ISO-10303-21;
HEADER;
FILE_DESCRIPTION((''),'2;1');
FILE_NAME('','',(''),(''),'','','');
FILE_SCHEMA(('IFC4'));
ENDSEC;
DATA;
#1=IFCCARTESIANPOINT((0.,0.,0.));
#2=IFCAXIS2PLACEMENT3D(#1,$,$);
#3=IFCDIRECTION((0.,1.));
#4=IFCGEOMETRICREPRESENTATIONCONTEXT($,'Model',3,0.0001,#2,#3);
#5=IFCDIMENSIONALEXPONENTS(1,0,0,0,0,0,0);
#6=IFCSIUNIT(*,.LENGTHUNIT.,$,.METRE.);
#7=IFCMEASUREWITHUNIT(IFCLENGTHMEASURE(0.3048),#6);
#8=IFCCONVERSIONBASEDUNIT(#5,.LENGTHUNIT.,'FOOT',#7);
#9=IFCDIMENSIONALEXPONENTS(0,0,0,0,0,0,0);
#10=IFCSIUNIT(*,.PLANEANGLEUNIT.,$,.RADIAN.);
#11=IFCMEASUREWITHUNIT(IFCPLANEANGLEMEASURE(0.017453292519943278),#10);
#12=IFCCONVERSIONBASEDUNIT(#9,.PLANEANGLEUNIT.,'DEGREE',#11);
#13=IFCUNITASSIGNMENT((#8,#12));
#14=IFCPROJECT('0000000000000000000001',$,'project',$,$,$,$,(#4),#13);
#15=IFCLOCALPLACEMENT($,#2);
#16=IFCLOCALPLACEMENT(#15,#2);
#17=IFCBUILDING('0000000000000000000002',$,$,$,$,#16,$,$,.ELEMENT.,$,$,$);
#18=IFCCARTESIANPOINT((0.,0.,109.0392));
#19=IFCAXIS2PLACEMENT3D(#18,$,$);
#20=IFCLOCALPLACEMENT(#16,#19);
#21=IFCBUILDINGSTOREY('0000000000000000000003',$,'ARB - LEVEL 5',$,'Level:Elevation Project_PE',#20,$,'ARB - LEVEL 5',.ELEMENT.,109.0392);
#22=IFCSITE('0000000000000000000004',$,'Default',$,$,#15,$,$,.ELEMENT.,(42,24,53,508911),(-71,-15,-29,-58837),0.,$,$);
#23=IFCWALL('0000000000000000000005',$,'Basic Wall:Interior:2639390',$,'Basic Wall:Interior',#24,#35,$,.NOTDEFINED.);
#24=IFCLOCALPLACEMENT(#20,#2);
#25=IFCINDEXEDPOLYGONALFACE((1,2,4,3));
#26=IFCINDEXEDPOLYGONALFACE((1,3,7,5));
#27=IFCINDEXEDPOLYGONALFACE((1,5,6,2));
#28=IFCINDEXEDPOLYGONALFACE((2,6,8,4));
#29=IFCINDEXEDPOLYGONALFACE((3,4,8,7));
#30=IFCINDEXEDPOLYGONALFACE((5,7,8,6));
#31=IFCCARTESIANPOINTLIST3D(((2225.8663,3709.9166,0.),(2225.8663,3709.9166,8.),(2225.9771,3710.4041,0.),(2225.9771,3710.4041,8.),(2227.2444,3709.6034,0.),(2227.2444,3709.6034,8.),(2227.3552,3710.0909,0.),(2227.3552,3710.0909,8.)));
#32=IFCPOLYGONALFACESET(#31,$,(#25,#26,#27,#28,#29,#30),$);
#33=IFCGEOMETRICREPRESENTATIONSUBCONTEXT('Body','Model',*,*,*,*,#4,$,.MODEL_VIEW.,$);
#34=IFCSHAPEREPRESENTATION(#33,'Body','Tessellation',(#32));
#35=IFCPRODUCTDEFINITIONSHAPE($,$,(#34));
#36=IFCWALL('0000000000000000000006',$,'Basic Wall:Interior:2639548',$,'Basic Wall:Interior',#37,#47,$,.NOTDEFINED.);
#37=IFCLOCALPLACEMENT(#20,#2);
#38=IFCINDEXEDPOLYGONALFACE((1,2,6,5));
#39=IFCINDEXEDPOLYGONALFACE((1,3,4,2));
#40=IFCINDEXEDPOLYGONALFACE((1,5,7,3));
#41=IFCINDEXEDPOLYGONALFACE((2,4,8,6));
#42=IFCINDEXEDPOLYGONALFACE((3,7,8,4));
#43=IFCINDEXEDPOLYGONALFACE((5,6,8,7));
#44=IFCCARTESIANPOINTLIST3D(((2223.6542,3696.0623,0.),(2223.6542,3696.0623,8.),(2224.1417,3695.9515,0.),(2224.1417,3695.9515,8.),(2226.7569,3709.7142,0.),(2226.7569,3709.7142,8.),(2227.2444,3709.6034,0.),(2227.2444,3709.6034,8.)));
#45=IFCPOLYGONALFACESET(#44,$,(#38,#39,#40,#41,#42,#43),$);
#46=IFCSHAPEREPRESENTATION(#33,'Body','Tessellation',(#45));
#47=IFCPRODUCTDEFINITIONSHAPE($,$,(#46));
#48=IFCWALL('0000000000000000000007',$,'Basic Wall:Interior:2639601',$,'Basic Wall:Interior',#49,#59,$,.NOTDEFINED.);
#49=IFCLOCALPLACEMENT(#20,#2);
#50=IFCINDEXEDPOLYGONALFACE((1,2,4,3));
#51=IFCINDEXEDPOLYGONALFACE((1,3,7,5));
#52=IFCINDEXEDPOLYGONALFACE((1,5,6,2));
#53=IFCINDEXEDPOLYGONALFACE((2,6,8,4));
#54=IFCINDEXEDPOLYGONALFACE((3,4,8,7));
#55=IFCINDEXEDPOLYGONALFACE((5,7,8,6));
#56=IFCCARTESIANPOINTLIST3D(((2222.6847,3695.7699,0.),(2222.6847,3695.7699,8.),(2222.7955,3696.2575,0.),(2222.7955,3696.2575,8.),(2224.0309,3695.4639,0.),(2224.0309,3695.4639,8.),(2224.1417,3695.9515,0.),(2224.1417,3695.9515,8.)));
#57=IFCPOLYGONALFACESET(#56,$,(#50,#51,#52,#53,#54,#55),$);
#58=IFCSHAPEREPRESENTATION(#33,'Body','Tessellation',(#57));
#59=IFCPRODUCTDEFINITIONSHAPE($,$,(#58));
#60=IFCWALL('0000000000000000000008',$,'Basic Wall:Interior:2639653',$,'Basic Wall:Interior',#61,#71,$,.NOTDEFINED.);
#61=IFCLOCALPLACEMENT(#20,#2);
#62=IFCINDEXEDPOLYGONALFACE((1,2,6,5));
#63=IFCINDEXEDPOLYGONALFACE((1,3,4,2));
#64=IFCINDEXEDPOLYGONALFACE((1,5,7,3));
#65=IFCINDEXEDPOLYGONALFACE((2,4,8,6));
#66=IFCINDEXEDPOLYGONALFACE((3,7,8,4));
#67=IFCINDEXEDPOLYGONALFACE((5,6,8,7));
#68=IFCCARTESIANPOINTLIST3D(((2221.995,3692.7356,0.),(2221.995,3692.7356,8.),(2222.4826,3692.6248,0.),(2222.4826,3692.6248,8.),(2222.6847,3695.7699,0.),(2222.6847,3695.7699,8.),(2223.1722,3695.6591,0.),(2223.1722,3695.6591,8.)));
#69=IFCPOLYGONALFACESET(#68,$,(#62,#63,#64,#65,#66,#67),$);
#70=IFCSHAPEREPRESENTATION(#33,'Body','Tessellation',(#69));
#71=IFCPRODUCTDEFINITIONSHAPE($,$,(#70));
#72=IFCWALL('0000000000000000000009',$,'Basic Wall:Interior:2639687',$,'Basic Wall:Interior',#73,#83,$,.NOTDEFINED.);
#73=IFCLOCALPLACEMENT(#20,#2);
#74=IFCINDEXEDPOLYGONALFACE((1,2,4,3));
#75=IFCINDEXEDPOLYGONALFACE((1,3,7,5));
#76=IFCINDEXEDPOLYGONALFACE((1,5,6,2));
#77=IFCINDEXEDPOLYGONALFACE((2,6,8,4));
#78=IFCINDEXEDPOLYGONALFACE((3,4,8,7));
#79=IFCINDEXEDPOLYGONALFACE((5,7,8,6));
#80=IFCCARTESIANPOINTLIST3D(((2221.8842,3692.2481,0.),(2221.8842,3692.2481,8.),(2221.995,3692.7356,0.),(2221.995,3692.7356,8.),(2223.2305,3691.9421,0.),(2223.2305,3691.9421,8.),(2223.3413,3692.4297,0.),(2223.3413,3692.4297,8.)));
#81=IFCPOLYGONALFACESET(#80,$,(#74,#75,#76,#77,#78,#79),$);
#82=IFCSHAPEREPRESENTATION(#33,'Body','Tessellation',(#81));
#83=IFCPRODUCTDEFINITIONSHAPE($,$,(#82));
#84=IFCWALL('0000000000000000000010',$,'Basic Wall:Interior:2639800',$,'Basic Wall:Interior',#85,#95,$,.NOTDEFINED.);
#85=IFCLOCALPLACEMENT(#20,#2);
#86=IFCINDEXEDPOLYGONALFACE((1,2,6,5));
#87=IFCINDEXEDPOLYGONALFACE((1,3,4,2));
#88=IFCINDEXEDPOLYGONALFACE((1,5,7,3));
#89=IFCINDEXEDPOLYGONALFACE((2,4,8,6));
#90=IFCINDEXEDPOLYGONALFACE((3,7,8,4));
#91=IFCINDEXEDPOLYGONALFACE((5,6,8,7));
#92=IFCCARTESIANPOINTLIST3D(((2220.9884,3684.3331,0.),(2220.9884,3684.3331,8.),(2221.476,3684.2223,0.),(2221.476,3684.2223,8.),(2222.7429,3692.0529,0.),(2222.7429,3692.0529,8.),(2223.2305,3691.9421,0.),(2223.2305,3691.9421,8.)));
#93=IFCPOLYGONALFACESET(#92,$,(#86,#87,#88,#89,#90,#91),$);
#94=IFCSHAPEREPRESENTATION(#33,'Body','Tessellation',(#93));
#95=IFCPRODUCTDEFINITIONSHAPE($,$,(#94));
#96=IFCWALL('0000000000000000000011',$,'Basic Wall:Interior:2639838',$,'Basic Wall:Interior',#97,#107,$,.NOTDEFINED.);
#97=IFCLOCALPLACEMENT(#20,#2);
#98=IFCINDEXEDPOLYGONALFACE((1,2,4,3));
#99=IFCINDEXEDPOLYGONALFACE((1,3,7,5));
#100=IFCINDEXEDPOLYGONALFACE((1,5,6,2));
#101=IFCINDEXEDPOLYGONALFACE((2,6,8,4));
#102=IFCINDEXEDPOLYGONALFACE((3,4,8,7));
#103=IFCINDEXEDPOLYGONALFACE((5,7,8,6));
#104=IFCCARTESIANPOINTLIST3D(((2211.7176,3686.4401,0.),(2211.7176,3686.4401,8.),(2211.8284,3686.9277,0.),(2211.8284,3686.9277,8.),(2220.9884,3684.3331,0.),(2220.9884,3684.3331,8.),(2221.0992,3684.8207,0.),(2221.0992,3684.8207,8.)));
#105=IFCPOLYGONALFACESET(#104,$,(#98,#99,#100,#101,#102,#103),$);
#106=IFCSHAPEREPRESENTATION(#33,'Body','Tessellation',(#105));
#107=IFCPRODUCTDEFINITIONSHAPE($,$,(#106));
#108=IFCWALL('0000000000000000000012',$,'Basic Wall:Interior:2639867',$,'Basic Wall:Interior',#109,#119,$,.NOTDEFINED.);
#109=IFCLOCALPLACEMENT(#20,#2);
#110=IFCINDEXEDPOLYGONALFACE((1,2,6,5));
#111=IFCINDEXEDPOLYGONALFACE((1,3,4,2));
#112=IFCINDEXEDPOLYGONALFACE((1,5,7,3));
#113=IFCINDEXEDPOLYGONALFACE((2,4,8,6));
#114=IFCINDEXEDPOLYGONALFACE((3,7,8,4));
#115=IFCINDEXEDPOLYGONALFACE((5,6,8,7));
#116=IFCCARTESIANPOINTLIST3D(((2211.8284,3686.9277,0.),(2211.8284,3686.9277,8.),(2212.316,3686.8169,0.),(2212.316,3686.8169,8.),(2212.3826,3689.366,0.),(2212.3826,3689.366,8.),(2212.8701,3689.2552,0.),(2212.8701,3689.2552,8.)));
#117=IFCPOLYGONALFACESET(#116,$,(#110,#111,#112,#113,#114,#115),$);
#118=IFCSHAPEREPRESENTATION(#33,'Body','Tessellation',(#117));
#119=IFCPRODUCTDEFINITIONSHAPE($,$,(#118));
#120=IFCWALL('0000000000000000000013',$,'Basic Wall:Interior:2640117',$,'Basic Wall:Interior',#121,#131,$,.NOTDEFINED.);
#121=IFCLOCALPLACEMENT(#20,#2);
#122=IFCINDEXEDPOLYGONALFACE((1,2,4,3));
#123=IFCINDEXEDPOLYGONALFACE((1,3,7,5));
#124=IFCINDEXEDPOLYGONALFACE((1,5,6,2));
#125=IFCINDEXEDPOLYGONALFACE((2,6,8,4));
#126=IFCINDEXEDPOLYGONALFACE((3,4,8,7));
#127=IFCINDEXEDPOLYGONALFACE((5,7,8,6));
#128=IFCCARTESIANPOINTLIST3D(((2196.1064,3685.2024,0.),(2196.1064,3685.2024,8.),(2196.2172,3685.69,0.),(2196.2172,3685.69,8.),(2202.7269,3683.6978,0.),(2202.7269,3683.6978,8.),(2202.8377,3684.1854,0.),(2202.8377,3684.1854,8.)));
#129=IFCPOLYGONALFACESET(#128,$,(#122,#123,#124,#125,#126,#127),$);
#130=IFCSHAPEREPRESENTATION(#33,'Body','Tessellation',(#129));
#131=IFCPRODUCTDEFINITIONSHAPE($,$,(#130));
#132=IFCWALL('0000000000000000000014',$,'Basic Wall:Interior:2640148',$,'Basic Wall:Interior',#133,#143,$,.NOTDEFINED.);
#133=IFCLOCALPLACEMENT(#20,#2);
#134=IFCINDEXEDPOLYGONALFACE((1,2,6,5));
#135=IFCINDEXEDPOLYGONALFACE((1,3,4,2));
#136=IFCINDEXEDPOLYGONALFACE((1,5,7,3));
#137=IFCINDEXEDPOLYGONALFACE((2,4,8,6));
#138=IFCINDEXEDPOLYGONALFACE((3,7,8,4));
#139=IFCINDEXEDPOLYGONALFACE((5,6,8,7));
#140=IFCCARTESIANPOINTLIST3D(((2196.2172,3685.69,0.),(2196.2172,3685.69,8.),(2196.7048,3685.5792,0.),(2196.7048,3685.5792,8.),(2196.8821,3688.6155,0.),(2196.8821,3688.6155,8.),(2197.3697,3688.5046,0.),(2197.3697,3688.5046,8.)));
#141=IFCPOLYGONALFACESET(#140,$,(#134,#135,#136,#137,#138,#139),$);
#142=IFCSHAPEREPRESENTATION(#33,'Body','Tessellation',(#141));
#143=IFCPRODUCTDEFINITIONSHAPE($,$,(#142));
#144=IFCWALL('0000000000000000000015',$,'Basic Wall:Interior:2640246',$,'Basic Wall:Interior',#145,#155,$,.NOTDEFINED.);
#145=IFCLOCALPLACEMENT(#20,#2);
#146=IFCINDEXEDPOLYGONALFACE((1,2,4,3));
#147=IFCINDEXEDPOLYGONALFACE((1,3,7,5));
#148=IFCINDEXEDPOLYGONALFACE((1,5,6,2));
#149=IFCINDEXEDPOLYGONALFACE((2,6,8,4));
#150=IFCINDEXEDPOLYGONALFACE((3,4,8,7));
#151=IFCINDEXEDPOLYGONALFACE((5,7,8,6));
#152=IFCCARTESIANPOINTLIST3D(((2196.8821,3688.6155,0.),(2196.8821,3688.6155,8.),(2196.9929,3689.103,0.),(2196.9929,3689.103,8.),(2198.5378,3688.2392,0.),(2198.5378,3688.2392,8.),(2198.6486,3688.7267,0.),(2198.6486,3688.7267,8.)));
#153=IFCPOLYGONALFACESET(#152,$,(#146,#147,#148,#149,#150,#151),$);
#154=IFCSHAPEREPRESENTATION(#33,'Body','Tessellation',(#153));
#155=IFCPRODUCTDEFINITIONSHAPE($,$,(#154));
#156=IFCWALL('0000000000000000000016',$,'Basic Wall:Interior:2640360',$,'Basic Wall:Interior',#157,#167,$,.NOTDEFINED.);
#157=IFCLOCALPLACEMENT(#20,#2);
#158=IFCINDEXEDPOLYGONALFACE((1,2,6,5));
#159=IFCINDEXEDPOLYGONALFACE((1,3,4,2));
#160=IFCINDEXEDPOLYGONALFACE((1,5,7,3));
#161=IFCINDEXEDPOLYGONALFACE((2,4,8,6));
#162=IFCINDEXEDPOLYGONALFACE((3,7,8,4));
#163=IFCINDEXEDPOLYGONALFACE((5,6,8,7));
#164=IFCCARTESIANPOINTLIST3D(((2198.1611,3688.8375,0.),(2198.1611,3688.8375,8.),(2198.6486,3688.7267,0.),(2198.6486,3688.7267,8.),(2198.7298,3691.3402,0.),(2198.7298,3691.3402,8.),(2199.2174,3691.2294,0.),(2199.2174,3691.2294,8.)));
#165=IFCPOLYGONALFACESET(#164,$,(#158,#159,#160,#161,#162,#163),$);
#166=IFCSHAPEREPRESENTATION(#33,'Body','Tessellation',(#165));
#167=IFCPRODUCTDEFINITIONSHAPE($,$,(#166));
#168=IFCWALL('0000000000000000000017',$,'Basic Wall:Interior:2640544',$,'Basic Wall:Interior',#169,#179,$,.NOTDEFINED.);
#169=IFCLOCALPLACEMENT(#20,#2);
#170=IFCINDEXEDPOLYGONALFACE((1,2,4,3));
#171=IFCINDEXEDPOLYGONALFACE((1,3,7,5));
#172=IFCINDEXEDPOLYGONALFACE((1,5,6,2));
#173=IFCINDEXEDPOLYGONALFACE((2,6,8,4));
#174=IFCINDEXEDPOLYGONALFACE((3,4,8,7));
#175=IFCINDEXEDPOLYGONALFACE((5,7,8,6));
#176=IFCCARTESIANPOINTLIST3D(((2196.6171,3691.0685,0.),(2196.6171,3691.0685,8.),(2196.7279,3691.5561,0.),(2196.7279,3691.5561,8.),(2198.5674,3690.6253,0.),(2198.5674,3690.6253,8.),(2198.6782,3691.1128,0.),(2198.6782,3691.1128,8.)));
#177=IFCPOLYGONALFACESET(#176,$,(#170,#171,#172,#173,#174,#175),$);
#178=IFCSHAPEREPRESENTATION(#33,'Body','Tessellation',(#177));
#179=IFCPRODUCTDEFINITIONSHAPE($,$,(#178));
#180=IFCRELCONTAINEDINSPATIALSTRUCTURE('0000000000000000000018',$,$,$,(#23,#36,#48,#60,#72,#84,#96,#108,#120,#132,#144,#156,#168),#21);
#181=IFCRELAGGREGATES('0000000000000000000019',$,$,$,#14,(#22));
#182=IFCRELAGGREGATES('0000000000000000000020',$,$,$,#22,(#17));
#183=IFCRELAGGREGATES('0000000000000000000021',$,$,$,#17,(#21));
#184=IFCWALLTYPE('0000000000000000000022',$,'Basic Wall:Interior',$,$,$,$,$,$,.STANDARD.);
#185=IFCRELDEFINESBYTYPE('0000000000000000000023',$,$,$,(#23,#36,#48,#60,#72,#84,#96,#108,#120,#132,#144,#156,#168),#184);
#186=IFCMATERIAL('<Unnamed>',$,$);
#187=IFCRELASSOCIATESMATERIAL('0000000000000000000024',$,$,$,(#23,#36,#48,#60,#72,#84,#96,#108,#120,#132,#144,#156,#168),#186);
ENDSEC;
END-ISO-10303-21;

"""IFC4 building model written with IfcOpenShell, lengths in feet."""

from ifc_helpers import new_model, entity, si_unit, converted_unit, direction, frame, origin, place, context, subcontext, project, spatial, indexed_curve, outline, extrude, material, type_object, element, save


model = new_model("IFC4")

# Units and contexts
model_context = context("Model", 3, precision=0.0001, world=origin(), true_north=direction((0.0, 1.0)))
body_context = subcontext(model_context, "Body", "Model", "MODEL_VIEW")
ifc_project = project(units=[converted_unit("LENGTHUNIT", "FOOT", entity("IfcLengthMeasure", 0.3048), si_unit("LENGTHUNIT", "METRE"), dimensions=[1, 0, 0, 0, 0, 0, 0]), converted_unit("PLANEANGLEUNIT", "DEGREE", entity("IfcPlaneAngleMeasure", 0.017453292519943278), si_unit("PLANEANGLEUNIT", "RADIAN"), dimensions=[0, 0, 0, 0, 0, 0, 0])], contexts=[model_context])

# Site, building, storey
site_placement = place(None, origin())
site = spatial("IfcSite", under=ifc_project, at=site_placement, Name="Default", CompositionType="ELEMENT", RefLatitude=(42, 24, 53, 508911), RefLongitude=(-71, -15, -29, -58837), RefElevation=0.0)
building_placement = place(site_placement, origin())
building = spatial("IfcBuilding", under=site, at=building_placement, CompositionType="ELEMENT")
storey_placement = place(building_placement, frame((0.0, 0.0, 109.0392)))
storey = spatial("IfcBuildingStorey", under=building, at=storey_placement, Name="ARB - LEVEL 5", ObjectType="Level:Elevation Project_PE", LongName="ARB - LEVEL 5", CompositionType="ELEMENT", Elevation=109.0392)

# Walls
ifc_material_1 = material(Name="<Unnamed>")
wall_type = type_object("IfcWallType", Name="Basic Wall:Interior", PredefinedType="STANDARD")
wall_1_placement = place(storey_placement, frame((2225.9217, 3710.1604, 0.0), z_axis=(0.0, 0.0, 1.0), x_axis=(0.975133, -0.221622, 0.0)))
element("IfcWall", 1, at=wall_1_placement, inside=storey, type_object=wall_type, material=ifc_material_1, Name="Basic Wall:Interior:2639390", ObjectType="Basic Wall:Interior", PredefinedType="NOTDEFINED", context=body_context, shape_type="SweptSolid", body=[
    extrude(outline(indexed_curve([(1.4132, 0.25), (0.0, 0.25), (0.0, -0.25), (1.4132, -0.25), (1.4132, 0.25)], self_intersect=False)), origin(), (0.0, 0.0, 1.0), 8.0),
])
wall_2_placement = place(storey_placement, frame((2227.0006, 3709.6588, 0.0), z_axis=(0.0, 0.0, 1.0), x_axis=(-0.221622, -0.975133, 0.0)))
element("IfcWall", 2, at=wall_2_placement, inside=storey, type_object=wall_type, material=ifc_material_1, Name="Basic Wall:Interior:2639548", ObjectType="Basic Wall:Interior", PredefinedType="NOTDEFINED", context=body_context, shape_type="SweptSolid", body=[
    extrude(outline(indexed_curve([(14.0, 0.25), (0.0, 0.25), (0.0, -0.25), (14.0, -0.25), (14.0, 0.25)], self_intersect=False)), origin(), (0.0, 0.0, 1.0), 8.0),
])
wall_3_placement = place(storey_placement, frame((2224.0863, 3695.7077, 0.0), z_axis=(0.0, 0.0, 1.0), x_axis=(-0.975133, 0.221622, 0.0)))
element("IfcWall", 3, at=wall_3_placement, inside=storey, type_object=wall_type, material=ifc_material_1, Name="Basic Wall:Interior:2639601", ObjectType="Basic Wall:Interior", PredefinedType="NOTDEFINED", context=body_context, shape_type="SweptSolid", body=[
    extrude(outline(indexed_curve([(1.3806, 0.25), (0.0, 0.25), (0.0, -0.25), (1.3806, -0.25), (1.3806, 0.25)], self_intersect=False)), origin(), (0.0, 0.0, 1.0), 8.0),
])
wall_4_placement = place(storey_placement, frame((2222.9284, 3695.7145, 0.0), z_axis=(0.0, 0.0, 1.0), x_axis=(-0.221622, -0.975133, 0.0)))
element("IfcWall", 4, at=wall_4_placement, inside=storey, type_object=wall_type, material=ifc_material_1, Name="Basic Wall:Interior:2639653", ObjectType="Basic Wall:Interior", PredefinedType="NOTDEFINED", context=body_context, shape_type="SweptSolid", body=[
    extrude(outline(indexed_curve([(3.1116, 0.25), (0.0, 0.25), (0.0, -0.25), (3.1116, -0.25), (3.1116, 0.25)], self_intersect=False)), origin(), (0.0, 0.0, 1.0), 8.0),
])
wall_5_placement = place(storey_placement, frame((2221.9396, 3692.4919, 0.0), z_axis=(0.0, 0.0, 1.0), x_axis=(0.975133, -0.221622, 0.0)))
element("IfcWall", 5, at=wall_5_placement, inside=storey, type_object=wall_type, material=ifc_material_1, Name="Basic Wall:Interior:2639687", ObjectType="Basic Wall:Interior", PredefinedType="NOTDEFINED", context=body_context, shape_type="SweptSolid", body=[
    extrude(outline(indexed_curve([(1.3806, 0.25), (0.0, 0.25), (0.0, -0.25), (1.3806, -0.25), (1.3806, 0.25)], self_intersect=False)), origin(), (0.0, 0.0, 1.0), 8.0),
])
wall_6_placement = place(storey_placement, frame((2222.9867, 3691.9975, 0.0), z_axis=(0.0, 0.0, 1.0), x_axis=(-0.221622, -0.975133, 0.0)))
element("IfcWall", 6, at=wall_6_placement, inside=storey, type_object=wall_type, material=ifc_material_1, Name="Basic Wall:Interior:2639800", ObjectType="Basic Wall:Interior", PredefinedType="NOTDEFINED", context=body_context, shape_type="SweptSolid", body=[
    extrude(outline(indexed_curve([(7.9167, 0.25), (0.0, 0.25), (0.0, -0.25), (7.9167, -0.25), (7.9167, 0.25)], self_intersect=False)), origin(), (0.0, 0.0, 1.0), 8.0),
])
wall_7_placement = place(storey_placement, frame((2221.0438, 3684.5769, 0.0), z_axis=(0.0, 0.0, 1.0), x_axis=(-0.975133, 0.221622, 0.0)))
element("IfcWall", 7, at=wall_7_placement, inside=storey, type_object=wall_type, material=ifc_material_1, Name="Basic Wall:Interior:2639838", ObjectType="Basic Wall:Interior", PredefinedType="NOTDEFINED", context=body_context, shape_type="SweptSolid", body=[
    extrude(outline(indexed_curve([(9.5072, 0.25), (0.0, 0.25), (0.0, -0.25), (9.5072, -0.25), (9.5072, 0.25)], self_intersect=False)), origin(), (0.0, 0.0, 1.0), 8.0),
])
wall_8_placement = place(storey_placement, frame((2212.0722, 3686.8723, 0.0), z_axis=(0.0, 0.0, 1.0), x_axis=(0.221622, 0.975133, 0.0)))
element("IfcWall", 8, at=wall_8_placement, inside=storey, type_object=wall_type, material=ifc_material_1, Name="Basic Wall:Interior:2639867", ObjectType="Basic Wall:Interior", PredefinedType="NOTDEFINED", context=body_context, shape_type="SweptSolid", body=[
    extrude(outline(indexed_curve([(2.5005, 0.25), (0.0, 0.25), (0.0, -0.25), (2.5005, -0.25), (2.5005, 0.25)], self_intersect=False)), origin(), (0.0, 0.0, 1.0), 8.0),
])
wall_9_placement = place(storey_placement, frame((2202.7823, 3683.9416, 0.0), z_axis=(0.0, 0.0, 1.0), x_axis=(-0.975133, 0.221622, 0.0)))
element("IfcWall", 9, at=wall_9_placement, inside=storey, type_object=wall_type, material=ifc_material_1, Name="Basic Wall:Interior:2640117", ObjectType="Basic Wall:Interior", PredefinedType="NOTDEFINED", context=body_context, shape_type="SweptSolid", body=[
    extrude(outline(indexed_curve([(6.7893, 0.25), (0.0, 0.25), (0.0, -0.25), (6.7893, -0.25), (6.7893, 0.25)], self_intersect=False)), origin(), (0.0, 0.0, 1.0), 8.0),
])
wall_10_placement = place(storey_placement, frame((2196.461, 3685.6346, 0.0), z_axis=(0.0, 0.0, 1.0), x_axis=(0.221622, 0.975133, 0.0)))
element("IfcWall", 10, at=wall_10_placement, inside=storey, type_object=wall_type, material=ifc_material_1, Name="Basic Wall:Interior:2640148", ObjectType="Basic Wall:Interior", PredefinedType="NOTDEFINED", context=body_context, shape_type="SweptSolid", body=[
    extrude(outline(indexed_curve([(3.0, 0.25), (0.0, 0.25), (0.0, -0.25), (3.0, -0.25), (3.0, 0.25)], self_intersect=False)), origin(), (0.0, 0.0, 1.0), 8.0),
])
wall_11_placement = place(storey_placement, frame((2196.9375, 3688.8592, 0.0), z_axis=(0.0, 0.0, 1.0), x_axis=(0.975133, -0.221622, 0.0)))
element("IfcWall", 11, at=wall_11_placement, inside=storey, type_object=wall_type, material=ifc_material_1, Name="Basic Wall:Interior:2640246", ObjectType="Basic Wall:Interior", PredefinedType="NOTDEFINED", context=body_context, shape_type="SweptSolid", body=[
    extrude(outline(indexed_curve([(1.6979, 0.25), (0.0, 0.25), (0.0, -0.25), (1.6979, -0.25), (1.6979, 0.25)], self_intersect=False)), origin(), (0.0, 0.0, 1.0), 8.0),
])
wall_12_placement = place(storey_placement, frame((2198.4048, 3688.7821, 0.0), z_axis=(0.0, 0.0, 1.0), x_axis=(0.221622, 0.975133, 0.0)))
element("IfcWall", 12, at=wall_12_placement, inside=storey, type_object=wall_type, material=ifc_material_1, Name="Basic Wall:Interior:2640360", ObjectType="Basic Wall:Interior", PredefinedType="NOTDEFINED", context=body_context, shape_type="SweptSolid", body=[
    extrude(outline(indexed_curve([(2.5665, 0.25), (0.0, 0.25), (0.0, -0.25), (2.5665, -0.25), (2.5665, 0.25)], self_intersect=False)), origin(), (0.0, 0.0, 1.0), 8.0),
])
wall_13_placement = place(storey_placement, frame((2198.6228, 3690.8691, 0.0), z_axis=(0.0, 0.0, 1.0), x_axis=(-0.975133, 0.221622, 0.0)))
element("IfcWall", 13, at=wall_13_placement, inside=storey, type_object=wall_type, material=ifc_material_1, Name="Basic Wall:Interior:2640544", ObjectType="Basic Wall:Interior", PredefinedType="NOTDEFINED", context=body_context, shape_type="SweptSolid", body=[
    extrude(outline(indexed_curve([(2.0, 0.25), (0.0, 0.25), (0.0, -0.25), (2.0, -0.25), (2.0, 0.25)], self_intersect=False)), origin(), (0.0, 0.0, 1.0), 8.0),
])

save(model, "model.ifc")
